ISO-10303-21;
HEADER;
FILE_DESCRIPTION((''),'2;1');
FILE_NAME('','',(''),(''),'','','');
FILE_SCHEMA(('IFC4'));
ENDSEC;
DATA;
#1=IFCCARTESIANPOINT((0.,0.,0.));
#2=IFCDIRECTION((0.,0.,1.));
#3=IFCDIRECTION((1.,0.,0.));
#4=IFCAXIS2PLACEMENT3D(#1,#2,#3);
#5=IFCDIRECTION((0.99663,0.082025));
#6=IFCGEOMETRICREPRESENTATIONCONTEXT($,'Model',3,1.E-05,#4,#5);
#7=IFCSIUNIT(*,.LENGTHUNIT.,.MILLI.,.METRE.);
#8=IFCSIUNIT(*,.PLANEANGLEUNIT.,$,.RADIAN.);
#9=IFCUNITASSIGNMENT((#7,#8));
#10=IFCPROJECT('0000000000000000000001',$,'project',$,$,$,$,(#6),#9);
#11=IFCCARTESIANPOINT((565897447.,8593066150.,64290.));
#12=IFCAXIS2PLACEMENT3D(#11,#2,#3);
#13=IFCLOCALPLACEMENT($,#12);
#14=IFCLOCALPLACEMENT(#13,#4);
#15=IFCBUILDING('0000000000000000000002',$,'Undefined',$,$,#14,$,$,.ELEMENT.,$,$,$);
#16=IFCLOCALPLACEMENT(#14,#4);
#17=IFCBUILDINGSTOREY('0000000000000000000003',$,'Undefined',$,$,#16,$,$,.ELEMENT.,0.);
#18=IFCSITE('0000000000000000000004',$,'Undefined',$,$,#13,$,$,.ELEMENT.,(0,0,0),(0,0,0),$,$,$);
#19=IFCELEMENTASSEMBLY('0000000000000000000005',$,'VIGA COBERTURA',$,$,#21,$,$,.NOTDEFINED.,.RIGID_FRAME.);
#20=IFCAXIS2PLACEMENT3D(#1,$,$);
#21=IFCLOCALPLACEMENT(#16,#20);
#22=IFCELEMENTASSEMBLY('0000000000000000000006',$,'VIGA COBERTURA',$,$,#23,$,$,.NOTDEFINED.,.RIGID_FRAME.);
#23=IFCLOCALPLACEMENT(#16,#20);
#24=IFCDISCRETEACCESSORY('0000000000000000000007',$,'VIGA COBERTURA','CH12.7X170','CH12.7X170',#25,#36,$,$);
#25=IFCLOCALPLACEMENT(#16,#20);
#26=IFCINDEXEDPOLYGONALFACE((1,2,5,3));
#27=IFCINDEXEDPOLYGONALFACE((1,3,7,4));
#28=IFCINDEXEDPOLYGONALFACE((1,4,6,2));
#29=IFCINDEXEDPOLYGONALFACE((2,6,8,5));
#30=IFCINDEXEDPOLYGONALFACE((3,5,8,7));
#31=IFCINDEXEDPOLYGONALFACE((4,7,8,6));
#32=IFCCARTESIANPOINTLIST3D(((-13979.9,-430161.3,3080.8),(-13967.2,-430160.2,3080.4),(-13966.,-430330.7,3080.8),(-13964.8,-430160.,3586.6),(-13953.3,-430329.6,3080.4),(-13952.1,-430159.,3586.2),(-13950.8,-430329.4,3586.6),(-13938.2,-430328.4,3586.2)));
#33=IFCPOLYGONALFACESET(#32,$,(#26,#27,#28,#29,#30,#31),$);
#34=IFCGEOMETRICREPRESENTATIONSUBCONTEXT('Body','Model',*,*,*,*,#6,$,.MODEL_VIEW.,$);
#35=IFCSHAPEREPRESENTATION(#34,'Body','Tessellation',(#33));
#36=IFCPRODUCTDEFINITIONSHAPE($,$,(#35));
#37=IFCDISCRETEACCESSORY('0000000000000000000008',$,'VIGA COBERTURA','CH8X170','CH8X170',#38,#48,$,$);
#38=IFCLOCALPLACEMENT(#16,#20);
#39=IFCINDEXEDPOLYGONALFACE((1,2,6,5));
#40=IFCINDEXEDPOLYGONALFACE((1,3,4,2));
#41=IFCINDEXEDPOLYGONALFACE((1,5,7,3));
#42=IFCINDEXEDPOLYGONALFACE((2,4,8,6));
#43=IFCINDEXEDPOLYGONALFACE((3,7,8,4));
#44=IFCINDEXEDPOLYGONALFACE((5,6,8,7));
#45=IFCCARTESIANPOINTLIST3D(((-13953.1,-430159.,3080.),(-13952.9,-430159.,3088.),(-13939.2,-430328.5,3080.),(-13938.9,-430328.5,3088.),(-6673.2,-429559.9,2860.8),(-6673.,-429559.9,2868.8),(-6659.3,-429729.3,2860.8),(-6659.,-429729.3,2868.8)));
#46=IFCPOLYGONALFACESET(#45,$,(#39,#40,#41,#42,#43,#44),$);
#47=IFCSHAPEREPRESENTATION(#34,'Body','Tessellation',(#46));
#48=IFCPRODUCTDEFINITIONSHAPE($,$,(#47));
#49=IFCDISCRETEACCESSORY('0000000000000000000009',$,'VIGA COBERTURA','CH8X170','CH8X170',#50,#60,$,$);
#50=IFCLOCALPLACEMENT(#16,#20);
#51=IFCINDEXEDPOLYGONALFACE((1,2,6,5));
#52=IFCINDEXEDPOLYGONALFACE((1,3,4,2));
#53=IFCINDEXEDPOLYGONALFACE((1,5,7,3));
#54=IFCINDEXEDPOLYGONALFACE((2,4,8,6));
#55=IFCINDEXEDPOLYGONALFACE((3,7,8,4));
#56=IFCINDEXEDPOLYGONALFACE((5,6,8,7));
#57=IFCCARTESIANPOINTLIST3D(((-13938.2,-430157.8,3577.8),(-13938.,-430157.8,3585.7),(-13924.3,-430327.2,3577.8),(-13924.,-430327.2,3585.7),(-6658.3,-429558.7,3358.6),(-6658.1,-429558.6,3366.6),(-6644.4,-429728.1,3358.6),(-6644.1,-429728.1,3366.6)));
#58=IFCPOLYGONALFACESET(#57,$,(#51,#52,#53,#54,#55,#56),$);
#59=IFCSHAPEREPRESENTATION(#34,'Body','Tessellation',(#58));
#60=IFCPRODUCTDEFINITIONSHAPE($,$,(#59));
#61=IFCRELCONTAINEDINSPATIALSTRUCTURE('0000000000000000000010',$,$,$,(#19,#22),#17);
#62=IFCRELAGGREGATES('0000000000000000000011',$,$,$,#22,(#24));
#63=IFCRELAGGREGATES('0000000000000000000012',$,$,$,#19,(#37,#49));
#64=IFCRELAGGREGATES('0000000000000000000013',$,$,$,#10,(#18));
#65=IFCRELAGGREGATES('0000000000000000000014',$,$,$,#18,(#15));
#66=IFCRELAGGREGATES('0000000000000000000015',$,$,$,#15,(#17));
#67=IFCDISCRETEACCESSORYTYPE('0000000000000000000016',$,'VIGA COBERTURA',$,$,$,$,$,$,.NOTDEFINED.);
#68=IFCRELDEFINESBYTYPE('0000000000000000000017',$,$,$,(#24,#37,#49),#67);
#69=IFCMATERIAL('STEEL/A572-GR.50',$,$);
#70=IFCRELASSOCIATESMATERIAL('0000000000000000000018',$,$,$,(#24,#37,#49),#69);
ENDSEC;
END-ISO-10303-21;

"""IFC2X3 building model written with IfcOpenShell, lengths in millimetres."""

from ifc_helpers import new_model, si_unit, direction, frame, origin_with_axes, origin_2d_with_axis, place, context, subcontext, project, spatial, polyline, rectangle, outline, extrude, material, type_object, element, aggregate, save


model = new_model("IFC2X3")

# Units and contexts
model_context = context("Model", 3, precision=1e-05, world=origin_with_axes(), true_north=direction((0.99663, 0.082025)))
body_context = subcontext(model_context, "Body", "Model", "MODEL_VIEW")
ifc_project = project(units=[si_unit("LENGTHUNIT", "METRE", prefix="MILLI"), si_unit("PLANEANGLEUNIT", "RADIAN")], contexts=[model_context])

# Site, building, storey
site_placement = place(None, frame((565897447.0, 8593066150.0, 64290.0), z_axis=(0.0, 0.0, 1.0), x_axis=(1.0, 0.0, 0.0)))
site = spatial("IfcSite", under=ifc_project, at=site_placement, Name="Undefined", CompositionType="ELEMENT", RefLatitude=(0, 0, 0), RefLongitude=(0, 0, 0))
building_placement = place(site_placement, origin_with_axes())
building = spatial("IfcBuilding", under=site, at=building_placement, Name="Undefined", CompositionType="ELEMENT")
storey_placement = place(building_placement, origin_with_axes())
storey = spatial("IfcBuildingStorey", under=building, at=storey_placement, Name="Undefined", CompositionType="ELEMENT", Elevation=0.0)

# Element assemblies, discrete accessory
assembly_1_placement = place(storey_placement, origin_with_axes())
assembly_1 = element("IfcElementAssembly", 1, at=assembly_1_placement, inside=storey, Name="VIGA COBERTURA", AssemblyPlace="NOTDEFINED", PredefinedType="RIGID_FRAME")
ifc_material_1 = material(Name="STEEL/A572-GR.50")
discrete_accessory_type_1 = type_object("IfcDiscreteAccessoryType", Name="VIGA COBERTURA")
assembly_2_placement = place(storey_placement, origin_with_axes())
assembly_2 = element("IfcElementAssembly", 2, at=assembly_2_placement, inside=storey, Name="VIGA COBERTURA", AssemblyPlace="NOTDEFINED", PredefinedType="RIGID_FRAME")
discrete_accessory_1_placement = place(assembly_2_placement, frame((-13951.5, -430244.2, 3586.4), z_axis=(-0.082025, 0.99663, 0.0), x_axis=(-0.029885, -0.00246, -0.99955)))
discrete_accessory_1 = element("IfcDiscreteAccessory", 3, at=discrete_accessory_1_placement, type_object=discrete_accessory_type_1, material=ifc_material_1, Name="VIGA COBERTURA", Description="CH12.7X170", ObjectType="CH12.7X170", context=body_context, shape_type="SweptSolid", body=[
    extrude(rectangle(XDim=12.7, YDim=170.0, at=origin_2d_with_axis()), frame((506.0, 0.0, 0.0), z_axis=(-1.0, 0.0, 0.0), x_axis=(0.0, -1.0, 0.0)), (0.0, 0.0, 1.0), 506.0),
])

# Discrete accessories
discrete_accessory_2_placement = place(assembly_1_placement, frame((-13946.0, -430243.7, 3084.0), z_axis=(-0.029885, -0.00246, -0.99955), x_axis=(0.996182, 0.081989, -0.029987)))
discrete_accessory_2 = element("IfcDiscreteAccessory", 4, at=discrete_accessory_2_placement, type_object=discrete_accessory_type_1, material=ifc_material_1, Name="VIGA COBERTURA", Description="CH8X170", ObjectType="CH8X170", context=body_context, shape_type="SweptSolid", body=[
    extrude(outline(polyline([(0.0, -85.0), (0.0, 85.0), (7307.8, 85.0), (7307.8, -85.0), (0.0, -85.0)])), frame((0.0, 0.0, -4.0), z_axis=(0.0, 0.0, 1.0), x_axis=(1.0, 0.0, 0.0)), (0.0, 0.0, 1.0), 8.0),
])
aggregate(assembly_2, [discrete_accessory_1])
discrete_accessory_3_placement = place(assembly_1_placement, frame((-13931.1, -430242.5, 3581.7), z_axis=(-0.029885, -0.00246, -0.99955), x_axis=(0.996182, 0.081989, -0.029987)))
discrete_accessory_3 = element("IfcDiscreteAccessory", 5, at=discrete_accessory_3_placement, type_object=discrete_accessory_type_1, material=ifc_material_1, Name="VIGA COBERTURA", Description="CH8X170", ObjectType="CH8X170", context=body_context, shape_type="SweptSolid", body=[
    extrude(outline(polyline([(0.0, -85.0), (0.0, 85.0), (7307.8, 85.0), (7307.8, -85.0), (0.0, -85.0)])), frame((0.0, 0.0, -4.0), z_axis=(0.0, 0.0, 1.0), x_axis=(1.0, 0.0, 0.0)), (0.0, 0.0, 1.0), 8.0),
])
aggregate(assembly_1, [discrete_accessory_2, discrete_accessory_3])

save(model, "model.ifc")
